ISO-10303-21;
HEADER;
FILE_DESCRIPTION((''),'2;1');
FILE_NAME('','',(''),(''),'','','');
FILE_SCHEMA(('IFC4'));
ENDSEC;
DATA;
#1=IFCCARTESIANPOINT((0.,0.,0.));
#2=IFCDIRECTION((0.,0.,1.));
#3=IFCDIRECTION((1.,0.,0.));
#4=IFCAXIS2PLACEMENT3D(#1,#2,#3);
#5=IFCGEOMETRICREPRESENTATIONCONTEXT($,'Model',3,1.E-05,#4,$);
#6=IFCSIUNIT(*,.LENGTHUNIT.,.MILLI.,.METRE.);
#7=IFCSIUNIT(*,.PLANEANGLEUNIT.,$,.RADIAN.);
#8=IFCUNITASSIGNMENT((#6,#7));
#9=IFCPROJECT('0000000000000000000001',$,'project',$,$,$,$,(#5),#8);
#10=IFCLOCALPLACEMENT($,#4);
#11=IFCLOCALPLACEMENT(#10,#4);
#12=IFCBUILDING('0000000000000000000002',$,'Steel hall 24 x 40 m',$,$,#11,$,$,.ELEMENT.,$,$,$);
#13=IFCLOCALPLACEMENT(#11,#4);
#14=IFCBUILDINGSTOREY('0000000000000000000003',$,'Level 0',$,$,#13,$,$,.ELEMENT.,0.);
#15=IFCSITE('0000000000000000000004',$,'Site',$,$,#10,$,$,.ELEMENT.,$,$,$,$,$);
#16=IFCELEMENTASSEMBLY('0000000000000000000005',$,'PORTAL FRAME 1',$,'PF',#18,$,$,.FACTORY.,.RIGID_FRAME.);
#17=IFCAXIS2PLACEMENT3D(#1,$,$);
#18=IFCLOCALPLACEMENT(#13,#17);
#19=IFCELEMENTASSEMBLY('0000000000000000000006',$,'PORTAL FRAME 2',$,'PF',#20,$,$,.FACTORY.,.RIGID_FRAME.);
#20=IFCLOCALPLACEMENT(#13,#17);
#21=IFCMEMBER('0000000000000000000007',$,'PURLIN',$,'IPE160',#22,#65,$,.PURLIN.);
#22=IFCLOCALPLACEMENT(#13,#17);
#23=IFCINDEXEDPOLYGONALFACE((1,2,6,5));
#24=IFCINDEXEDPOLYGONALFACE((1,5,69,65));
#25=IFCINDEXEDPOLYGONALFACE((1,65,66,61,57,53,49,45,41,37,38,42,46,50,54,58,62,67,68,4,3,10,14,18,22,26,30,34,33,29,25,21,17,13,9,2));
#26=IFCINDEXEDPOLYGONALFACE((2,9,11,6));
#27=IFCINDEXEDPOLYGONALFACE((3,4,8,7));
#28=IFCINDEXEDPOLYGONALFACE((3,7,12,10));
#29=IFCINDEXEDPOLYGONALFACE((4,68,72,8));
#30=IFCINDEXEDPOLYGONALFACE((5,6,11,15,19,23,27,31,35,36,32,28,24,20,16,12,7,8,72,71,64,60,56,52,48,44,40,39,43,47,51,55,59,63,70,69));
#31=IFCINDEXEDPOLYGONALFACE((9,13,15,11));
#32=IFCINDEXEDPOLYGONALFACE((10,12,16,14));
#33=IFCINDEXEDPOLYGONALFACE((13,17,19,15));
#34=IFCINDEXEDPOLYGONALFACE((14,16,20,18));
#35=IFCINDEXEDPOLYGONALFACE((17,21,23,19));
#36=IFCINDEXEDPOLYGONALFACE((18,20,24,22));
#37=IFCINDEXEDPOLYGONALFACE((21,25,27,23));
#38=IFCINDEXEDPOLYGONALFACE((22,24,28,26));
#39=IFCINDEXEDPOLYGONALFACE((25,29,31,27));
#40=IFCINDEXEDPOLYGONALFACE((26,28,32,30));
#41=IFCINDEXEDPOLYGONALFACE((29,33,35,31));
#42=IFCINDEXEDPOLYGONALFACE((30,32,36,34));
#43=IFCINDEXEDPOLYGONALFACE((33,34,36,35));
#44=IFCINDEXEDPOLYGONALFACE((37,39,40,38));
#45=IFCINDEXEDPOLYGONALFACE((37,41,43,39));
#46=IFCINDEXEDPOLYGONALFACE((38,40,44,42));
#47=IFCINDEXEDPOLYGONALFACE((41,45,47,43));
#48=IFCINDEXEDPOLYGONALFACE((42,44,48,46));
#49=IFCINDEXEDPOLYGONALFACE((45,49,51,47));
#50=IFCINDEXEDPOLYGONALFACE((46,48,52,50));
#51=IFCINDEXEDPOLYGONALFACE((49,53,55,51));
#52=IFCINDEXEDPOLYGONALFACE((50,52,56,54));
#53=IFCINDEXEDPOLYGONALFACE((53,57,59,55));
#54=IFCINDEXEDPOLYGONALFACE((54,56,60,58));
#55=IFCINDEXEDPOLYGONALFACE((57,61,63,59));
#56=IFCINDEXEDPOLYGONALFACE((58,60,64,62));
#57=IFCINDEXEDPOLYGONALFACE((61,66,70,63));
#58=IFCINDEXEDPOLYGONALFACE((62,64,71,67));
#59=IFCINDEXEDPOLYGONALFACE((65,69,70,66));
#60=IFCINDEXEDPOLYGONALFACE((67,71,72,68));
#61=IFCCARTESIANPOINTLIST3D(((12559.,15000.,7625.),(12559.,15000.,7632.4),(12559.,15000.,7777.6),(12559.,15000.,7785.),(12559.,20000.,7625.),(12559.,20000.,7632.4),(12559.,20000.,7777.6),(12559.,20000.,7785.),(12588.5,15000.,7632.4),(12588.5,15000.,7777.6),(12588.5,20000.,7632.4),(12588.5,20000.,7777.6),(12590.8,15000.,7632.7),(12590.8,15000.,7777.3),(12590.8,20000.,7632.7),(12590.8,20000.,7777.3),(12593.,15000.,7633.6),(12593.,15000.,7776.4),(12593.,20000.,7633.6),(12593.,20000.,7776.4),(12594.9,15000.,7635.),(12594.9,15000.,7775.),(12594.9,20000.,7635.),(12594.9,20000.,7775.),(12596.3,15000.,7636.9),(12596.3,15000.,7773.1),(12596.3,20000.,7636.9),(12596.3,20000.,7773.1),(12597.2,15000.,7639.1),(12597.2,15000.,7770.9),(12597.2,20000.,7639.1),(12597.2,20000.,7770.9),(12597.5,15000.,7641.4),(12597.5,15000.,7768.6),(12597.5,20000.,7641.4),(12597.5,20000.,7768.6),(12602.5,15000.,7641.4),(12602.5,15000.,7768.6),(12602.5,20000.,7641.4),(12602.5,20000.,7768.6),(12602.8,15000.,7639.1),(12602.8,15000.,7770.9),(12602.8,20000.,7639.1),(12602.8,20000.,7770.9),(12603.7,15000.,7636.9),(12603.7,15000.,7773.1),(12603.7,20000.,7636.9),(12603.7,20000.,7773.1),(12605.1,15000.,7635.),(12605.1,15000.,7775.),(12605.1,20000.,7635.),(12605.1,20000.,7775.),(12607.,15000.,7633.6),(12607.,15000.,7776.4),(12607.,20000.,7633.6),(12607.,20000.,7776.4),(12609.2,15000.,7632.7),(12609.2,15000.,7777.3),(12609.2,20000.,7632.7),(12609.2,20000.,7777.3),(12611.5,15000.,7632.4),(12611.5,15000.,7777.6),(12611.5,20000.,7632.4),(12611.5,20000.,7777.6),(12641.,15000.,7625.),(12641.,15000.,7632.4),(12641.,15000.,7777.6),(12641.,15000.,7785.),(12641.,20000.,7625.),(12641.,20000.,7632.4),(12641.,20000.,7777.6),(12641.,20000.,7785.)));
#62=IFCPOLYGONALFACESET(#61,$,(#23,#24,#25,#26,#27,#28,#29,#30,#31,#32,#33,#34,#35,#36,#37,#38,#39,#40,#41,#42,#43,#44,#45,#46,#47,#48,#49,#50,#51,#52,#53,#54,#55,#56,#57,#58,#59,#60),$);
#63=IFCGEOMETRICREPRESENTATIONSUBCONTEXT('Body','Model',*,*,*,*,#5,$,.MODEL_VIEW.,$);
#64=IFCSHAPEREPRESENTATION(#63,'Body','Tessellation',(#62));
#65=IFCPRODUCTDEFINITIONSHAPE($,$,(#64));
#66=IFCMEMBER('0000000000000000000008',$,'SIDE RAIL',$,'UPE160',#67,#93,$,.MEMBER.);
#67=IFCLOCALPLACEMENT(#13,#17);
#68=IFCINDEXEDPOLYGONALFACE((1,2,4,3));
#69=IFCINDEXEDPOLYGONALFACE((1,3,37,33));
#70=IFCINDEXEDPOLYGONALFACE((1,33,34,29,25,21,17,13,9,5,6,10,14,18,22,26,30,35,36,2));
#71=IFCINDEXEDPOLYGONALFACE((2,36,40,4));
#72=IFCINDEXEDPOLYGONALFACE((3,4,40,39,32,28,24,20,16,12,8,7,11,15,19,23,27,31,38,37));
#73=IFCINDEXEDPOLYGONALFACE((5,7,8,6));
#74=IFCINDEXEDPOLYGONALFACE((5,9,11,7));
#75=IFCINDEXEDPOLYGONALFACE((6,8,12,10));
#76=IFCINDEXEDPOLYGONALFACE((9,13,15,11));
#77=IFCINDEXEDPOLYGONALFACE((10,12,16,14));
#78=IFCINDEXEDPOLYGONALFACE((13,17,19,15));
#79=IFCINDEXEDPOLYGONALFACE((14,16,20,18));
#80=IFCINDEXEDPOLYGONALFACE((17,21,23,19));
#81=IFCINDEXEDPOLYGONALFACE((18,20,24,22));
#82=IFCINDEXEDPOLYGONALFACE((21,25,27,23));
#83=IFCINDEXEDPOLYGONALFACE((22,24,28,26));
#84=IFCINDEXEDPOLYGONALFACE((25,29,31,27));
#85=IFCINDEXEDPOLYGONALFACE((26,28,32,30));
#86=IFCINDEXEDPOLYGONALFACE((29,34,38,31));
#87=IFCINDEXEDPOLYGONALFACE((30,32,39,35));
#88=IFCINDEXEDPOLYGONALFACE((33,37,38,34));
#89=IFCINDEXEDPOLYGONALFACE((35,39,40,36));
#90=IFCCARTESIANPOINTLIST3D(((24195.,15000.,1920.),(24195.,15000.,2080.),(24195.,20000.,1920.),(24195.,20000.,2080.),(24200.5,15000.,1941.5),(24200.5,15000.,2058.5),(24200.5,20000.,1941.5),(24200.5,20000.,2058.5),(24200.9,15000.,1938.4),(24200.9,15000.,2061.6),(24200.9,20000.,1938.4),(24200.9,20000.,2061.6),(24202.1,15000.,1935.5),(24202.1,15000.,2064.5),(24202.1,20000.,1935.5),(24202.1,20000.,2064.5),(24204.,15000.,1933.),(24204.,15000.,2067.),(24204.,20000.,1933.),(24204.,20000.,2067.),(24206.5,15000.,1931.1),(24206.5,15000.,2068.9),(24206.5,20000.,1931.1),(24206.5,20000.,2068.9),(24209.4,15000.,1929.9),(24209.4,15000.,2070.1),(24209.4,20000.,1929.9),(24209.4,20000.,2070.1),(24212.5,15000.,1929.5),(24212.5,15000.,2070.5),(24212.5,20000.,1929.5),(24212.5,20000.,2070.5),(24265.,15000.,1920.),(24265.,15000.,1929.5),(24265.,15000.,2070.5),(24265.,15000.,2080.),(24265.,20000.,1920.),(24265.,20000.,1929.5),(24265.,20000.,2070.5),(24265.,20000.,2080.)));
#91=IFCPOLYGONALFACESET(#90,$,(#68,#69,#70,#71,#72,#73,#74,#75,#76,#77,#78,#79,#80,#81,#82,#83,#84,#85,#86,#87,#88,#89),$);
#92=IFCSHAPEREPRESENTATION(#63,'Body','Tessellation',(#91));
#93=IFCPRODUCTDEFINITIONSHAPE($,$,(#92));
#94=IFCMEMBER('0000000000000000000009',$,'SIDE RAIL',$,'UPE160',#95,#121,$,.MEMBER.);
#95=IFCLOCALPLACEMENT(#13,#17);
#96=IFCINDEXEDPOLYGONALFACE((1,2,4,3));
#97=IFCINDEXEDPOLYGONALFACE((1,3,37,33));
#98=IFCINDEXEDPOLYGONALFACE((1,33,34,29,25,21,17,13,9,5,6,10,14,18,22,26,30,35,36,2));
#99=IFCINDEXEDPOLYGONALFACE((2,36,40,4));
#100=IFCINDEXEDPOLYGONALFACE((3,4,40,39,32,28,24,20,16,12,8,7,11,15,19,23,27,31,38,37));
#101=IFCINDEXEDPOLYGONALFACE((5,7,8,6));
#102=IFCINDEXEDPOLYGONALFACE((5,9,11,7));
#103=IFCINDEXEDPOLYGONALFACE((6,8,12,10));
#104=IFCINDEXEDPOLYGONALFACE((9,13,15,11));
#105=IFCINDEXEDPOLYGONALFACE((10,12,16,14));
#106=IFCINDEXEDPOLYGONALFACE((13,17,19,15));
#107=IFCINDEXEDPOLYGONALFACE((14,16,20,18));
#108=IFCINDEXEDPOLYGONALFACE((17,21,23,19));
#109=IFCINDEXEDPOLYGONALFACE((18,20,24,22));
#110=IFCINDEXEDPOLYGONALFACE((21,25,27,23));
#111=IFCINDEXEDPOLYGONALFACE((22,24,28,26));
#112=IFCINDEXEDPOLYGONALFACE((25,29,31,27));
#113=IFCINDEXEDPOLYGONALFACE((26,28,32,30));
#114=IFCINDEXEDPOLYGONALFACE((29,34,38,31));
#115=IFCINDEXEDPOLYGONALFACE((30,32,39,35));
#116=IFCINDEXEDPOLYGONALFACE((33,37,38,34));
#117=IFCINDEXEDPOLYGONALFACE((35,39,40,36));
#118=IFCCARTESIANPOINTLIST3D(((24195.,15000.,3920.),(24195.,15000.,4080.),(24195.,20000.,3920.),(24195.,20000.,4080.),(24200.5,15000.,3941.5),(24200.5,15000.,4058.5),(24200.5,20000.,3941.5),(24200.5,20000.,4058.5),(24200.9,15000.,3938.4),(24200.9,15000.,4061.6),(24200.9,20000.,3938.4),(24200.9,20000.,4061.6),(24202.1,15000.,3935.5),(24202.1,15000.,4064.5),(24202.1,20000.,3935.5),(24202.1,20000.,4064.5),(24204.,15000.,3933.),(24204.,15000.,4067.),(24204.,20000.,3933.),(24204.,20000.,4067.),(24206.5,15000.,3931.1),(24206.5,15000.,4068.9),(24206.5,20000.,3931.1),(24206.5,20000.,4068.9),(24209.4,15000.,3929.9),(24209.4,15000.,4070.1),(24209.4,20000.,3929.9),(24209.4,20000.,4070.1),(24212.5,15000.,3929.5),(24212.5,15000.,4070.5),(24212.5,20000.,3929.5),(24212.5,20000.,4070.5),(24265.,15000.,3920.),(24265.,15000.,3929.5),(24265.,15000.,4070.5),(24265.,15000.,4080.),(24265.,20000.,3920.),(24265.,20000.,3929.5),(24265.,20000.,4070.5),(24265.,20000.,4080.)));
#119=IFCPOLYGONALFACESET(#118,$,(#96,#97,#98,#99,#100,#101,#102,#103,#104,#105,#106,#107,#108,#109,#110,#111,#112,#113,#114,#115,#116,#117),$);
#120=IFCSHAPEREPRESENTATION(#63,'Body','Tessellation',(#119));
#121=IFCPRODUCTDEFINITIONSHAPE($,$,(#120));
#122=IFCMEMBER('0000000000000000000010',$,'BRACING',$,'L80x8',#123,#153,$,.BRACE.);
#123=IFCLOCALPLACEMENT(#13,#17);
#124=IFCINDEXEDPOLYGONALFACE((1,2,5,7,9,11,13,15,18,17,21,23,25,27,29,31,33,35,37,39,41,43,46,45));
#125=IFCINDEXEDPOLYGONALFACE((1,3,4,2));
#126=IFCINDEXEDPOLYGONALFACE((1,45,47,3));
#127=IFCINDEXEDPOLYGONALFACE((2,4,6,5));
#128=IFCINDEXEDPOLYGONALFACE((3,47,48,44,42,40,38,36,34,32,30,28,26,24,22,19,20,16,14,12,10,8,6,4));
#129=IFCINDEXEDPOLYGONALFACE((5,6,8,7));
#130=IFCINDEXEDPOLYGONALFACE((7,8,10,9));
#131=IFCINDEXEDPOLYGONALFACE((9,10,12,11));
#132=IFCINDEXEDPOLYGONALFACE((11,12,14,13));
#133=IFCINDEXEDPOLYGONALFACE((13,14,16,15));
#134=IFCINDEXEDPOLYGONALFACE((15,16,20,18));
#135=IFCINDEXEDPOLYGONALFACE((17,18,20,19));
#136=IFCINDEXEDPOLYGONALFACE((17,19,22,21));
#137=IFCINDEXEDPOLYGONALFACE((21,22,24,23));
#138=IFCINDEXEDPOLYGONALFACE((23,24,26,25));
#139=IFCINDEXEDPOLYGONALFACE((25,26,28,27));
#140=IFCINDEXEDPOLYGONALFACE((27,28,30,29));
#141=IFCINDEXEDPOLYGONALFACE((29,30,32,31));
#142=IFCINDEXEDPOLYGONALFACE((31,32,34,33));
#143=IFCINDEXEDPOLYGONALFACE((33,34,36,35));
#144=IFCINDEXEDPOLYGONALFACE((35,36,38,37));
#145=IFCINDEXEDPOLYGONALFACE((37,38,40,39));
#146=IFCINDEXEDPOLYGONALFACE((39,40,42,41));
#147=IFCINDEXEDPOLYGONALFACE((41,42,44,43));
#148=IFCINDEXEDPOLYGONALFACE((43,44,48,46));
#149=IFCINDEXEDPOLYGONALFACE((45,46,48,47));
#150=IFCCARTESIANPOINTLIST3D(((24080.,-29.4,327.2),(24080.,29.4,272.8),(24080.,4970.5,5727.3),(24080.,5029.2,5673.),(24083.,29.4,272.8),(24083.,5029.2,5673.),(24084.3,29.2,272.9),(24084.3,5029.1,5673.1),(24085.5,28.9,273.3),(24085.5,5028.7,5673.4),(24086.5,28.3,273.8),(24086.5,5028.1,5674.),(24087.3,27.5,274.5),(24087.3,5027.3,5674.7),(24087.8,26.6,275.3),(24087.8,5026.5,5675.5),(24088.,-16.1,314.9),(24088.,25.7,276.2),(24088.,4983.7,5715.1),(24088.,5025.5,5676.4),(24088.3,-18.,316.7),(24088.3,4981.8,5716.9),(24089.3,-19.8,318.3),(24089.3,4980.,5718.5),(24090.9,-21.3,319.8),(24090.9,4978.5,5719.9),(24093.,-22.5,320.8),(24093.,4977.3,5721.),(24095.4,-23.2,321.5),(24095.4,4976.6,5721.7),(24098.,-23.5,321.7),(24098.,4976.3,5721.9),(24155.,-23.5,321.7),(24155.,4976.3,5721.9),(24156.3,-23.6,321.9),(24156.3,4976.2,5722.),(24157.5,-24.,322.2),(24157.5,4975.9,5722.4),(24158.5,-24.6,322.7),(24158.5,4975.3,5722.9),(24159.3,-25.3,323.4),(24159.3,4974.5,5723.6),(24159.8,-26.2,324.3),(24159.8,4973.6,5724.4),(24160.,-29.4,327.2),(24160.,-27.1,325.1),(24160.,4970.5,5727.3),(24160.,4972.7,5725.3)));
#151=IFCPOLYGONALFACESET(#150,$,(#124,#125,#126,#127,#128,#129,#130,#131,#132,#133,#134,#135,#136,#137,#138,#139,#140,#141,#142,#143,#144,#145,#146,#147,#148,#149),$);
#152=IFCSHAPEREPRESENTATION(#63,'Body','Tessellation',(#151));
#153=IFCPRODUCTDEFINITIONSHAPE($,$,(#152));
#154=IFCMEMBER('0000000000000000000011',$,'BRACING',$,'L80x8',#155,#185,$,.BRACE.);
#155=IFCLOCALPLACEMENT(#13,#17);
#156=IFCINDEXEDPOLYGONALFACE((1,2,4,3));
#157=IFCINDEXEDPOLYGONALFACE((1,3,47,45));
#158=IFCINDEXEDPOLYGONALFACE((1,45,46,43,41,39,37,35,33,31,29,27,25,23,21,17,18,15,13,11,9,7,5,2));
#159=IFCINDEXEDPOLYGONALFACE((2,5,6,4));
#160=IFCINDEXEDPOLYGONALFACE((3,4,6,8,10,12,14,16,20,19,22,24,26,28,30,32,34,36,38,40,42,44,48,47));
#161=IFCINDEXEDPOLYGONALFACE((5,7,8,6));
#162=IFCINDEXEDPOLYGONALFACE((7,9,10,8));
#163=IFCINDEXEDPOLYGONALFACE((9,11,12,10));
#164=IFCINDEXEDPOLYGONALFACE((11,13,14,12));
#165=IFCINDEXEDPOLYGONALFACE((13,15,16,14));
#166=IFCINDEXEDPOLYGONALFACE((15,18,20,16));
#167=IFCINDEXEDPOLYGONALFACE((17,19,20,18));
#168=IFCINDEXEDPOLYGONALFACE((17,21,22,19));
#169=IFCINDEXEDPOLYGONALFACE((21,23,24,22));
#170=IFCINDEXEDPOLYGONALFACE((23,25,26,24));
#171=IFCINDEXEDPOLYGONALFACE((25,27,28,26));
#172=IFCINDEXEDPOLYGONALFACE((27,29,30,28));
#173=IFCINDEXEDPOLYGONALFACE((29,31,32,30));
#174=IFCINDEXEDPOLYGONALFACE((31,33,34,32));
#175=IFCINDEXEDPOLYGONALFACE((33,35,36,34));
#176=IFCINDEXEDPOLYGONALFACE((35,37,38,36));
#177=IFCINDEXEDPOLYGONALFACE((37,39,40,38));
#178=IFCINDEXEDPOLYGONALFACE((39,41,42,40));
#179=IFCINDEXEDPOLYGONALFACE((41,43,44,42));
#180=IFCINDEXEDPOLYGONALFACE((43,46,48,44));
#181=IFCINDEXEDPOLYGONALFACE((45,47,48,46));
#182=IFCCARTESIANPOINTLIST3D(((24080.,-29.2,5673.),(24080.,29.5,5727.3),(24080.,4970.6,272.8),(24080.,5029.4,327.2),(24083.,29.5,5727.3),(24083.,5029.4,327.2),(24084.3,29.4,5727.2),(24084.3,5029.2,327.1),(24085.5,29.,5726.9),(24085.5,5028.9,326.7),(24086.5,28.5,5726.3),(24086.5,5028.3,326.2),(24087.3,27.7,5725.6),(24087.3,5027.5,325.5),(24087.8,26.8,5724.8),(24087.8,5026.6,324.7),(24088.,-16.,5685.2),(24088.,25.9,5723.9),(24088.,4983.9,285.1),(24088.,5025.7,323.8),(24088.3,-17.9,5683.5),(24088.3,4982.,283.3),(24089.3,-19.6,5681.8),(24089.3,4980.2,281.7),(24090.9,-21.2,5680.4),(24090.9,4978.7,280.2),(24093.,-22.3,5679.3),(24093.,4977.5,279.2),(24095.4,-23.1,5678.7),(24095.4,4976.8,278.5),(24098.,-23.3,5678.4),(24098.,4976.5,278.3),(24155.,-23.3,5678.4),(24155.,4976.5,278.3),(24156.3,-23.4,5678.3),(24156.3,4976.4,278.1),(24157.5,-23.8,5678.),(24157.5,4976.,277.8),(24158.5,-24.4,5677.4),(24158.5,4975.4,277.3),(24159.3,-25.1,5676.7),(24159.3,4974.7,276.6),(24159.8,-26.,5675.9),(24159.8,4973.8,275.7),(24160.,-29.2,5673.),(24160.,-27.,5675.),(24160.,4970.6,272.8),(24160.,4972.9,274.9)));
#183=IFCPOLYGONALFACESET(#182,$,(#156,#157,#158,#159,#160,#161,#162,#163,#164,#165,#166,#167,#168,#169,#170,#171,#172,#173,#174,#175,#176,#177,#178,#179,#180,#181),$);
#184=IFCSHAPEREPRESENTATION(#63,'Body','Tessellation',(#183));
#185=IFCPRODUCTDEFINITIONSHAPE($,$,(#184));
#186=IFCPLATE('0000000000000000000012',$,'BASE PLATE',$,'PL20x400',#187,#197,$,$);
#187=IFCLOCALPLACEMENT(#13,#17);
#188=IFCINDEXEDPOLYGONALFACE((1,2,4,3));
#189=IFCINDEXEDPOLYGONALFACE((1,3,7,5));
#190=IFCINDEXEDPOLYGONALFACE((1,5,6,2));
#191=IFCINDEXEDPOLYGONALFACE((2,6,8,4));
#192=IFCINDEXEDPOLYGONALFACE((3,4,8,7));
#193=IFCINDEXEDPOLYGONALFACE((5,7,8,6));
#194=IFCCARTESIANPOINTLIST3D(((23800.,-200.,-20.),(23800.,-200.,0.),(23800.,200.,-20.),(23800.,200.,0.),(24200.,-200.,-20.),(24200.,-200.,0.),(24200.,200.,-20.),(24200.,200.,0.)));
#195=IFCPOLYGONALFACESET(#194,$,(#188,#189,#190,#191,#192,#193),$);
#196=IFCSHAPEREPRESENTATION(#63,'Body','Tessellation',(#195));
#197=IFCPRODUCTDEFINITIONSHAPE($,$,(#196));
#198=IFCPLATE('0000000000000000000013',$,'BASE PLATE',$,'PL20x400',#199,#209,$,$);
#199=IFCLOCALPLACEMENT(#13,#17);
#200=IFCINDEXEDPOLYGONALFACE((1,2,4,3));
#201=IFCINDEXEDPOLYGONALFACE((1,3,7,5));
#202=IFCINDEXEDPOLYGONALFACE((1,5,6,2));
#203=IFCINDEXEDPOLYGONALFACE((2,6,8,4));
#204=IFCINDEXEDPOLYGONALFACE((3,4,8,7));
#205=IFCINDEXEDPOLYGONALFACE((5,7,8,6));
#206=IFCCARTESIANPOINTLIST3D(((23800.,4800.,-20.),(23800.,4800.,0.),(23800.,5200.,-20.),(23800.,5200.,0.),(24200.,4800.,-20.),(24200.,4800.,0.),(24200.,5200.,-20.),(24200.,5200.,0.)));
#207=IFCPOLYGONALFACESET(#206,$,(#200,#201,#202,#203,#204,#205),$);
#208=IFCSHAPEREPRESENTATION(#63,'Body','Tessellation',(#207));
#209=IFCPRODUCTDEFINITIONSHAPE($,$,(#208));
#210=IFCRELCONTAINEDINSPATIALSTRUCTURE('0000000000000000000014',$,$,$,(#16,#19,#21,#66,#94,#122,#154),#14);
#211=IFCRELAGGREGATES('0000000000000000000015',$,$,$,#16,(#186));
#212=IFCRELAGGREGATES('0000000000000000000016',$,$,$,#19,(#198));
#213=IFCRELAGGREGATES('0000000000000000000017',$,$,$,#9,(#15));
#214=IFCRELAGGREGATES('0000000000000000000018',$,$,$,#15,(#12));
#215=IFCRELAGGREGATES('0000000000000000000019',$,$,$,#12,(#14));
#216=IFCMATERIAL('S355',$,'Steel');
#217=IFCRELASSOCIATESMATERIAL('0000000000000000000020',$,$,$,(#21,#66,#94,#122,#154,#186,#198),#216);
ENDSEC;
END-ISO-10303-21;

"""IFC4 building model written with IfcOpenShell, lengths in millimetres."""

from ifc_helpers import new_model, si_unit, frame, origin_with_axes, place, context, subcontext, project, spatial, rectangle, i_section, l_section, u_section, extrude, material, element, aggregate, save


model = new_model("IFC4")

# Units and contexts
model_context = context("Model", 3, precision=1e-05, world=origin_with_axes())
body_context = subcontext(model_context, "Body", "Model", "MODEL_VIEW")
ifc_project = project(units=[si_unit("LENGTHUNIT", "METRE", prefix="MILLI"), si_unit("PLANEANGLEUNIT", "RADIAN")], contexts=[model_context])

# Site, building, storey
site_placement = place(None, origin_with_axes())
site = spatial("IfcSite", under=ifc_project, at=site_placement, Name="Site", CompositionType="ELEMENT")
building_placement = place(site_placement, origin_with_axes())
building = spatial("IfcBuilding", under=site, at=building_placement, Name="Steel hall 24 x 40 m", CompositionType="ELEMENT")
storey_placement = place(building_placement, origin_with_axes())
storey = spatial("IfcBuildingStorey", under=building, at=storey_placement, Name="Level 0", CompositionType="ELEMENT", Elevation=0.0)

# Element assemblies
assembly_1_placement = place(storey_placement, origin_with_axes())
assembly_1 = element("IfcElementAssembly", 1, at=assembly_1_placement, inside=storey, Name="PORTAL FRAME 1", ObjectType="PF", AssemblyPlace="FACTORY", PredefinedType="RIGID_FRAME")
ifc_material = material(Name="S355", Category="Steel")
assembly_2_placement = place(storey_placement, frame((0.0, 5000.0, 0.0), z_axis=(0.0, 0.0, 1.0), x_axis=(1.0, 0.0, 0.0)))
assembly_2 = element("IfcElementAssembly", 2, at=assembly_2_placement, inside=storey, Name="PORTAL FRAME 2", ObjectType="PF", AssemblyPlace="FACTORY", PredefinedType="RIGID_FRAME")

# Members
for number, where, z_axis, x_axis, name in (
    (3, (12600.0, 15000.0, 7705.0), (0.0, 1.0, 0.0), (1.0, 0.0, 0.0), "PURLIN"),
):
    element("IfcMember", number, at=place(storey_placement, frame(where, z_axis=z_axis, x_axis=x_axis)), inside=storey, material=ifc_material, Name=name, ObjectType="IPE160", PredefinedType="PURLIN", context=body_context, shape_type="SweptSolid", body=[
        extrude(i_section(OverallWidth=82.0, OverallDepth=160.0, WebThickness=5.0, FlangeThickness=7.4, FilletRadius=9.0), origin_with_axes(), (0.0, 0.0, 1.0), 5000.0),
    ])
for number, where, z_axis, x_axis, name in (
    (4, (24230.0, 15000.0, 2000.0), (0.0, 1.0, 0.0), (1.0, 0.0, 0.0), "SIDE RAIL"),
    (5, (24230.0, 15000.0, 4000.0), (0.0, 1.0, 0.0), (1.0, 0.0, 0.0), "SIDE RAIL"),
):
    element("IfcMember", number, at=place(storey_placement, frame(where, z_axis=z_axis, x_axis=x_axis)), inside=storey, material=ifc_material, Name=name, ObjectType="UPE160", PredefinedType="MEMBER", context=body_context, shape_type="SweptSolid", body=[
        extrude(u_section(Depth=160.0, FlangeWidth=70.0, WebThickness=5.5, FlangeThickness=9.5, FilletRadius=12.0), origin_with_axes(), (0.0, 0.0, 1.0), 5000.0),
    ])
for number, where, z_axis, x_axis, name in (
    (6, (24120.0, 0.0, 300.0), (0.0, 0.6794, 0.7338), (1.0, 0.0, 0.0), "BRACING"),
    (7, (24120.0, 5000.0, 300.0), (0.0, -0.6794, 0.7338), (1.0, 0.0, 0.0), "BRACING"),
):
    element("IfcMember", number, at=place(storey_placement, frame(where, z_axis=z_axis, x_axis=x_axis)), inside=storey, material=ifc_material, Name=name, ObjectType="L80x8", PredefinedType="BRACE", context=body_context, shape_type="SweptSolid", body=[
        extrude(l_section(Depth=80.0, Width=80.0, Thickness=8.0, FilletRadius=10.0, EdgeRadius=5.0), origin_with_axes(), (0.0, 0.0, 1.0), 7359.3),
    ])

# Plates
plate_1_placement = place(storey_placement, frame((24000.0, 0.0, -20.0), z_axis=(0.0, 0.0, 1.0), x_axis=(1.0, 0.0, 0.0)))
plate_1 = element("IfcPlate", 8, at=plate_1_placement, material=ifc_material, Name="BASE PLATE", ObjectType="PL20x400", context=body_context, shape_type="SweptSolid", body=[
    extrude(rectangle(XDim=400.0, YDim=400.0), origin_with_axes(), (0.0, 0.0, 1.0), 20.0),
])
aggregate(assembly_1, [plate_1])
plate_2_placement = place(storey_placement, frame((24000.0, 5000.0, -20.0), z_axis=(0.0, 0.0, 1.0), x_axis=(1.0, 0.0, 0.0)))
plate_2 = element("IfcPlate", 9, at=plate_2_placement, material=ifc_material, Name="BASE PLATE", ObjectType="PL20x400", context=body_context, shape_type="SweptSolid", body=[
    extrude(rectangle(XDim=400.0, YDim=400.0), origin_with_axes(), (0.0, 0.0, 1.0), 20.0),
])
aggregate(assembly_2, [plate_2])

save(model, "model.ifc")
